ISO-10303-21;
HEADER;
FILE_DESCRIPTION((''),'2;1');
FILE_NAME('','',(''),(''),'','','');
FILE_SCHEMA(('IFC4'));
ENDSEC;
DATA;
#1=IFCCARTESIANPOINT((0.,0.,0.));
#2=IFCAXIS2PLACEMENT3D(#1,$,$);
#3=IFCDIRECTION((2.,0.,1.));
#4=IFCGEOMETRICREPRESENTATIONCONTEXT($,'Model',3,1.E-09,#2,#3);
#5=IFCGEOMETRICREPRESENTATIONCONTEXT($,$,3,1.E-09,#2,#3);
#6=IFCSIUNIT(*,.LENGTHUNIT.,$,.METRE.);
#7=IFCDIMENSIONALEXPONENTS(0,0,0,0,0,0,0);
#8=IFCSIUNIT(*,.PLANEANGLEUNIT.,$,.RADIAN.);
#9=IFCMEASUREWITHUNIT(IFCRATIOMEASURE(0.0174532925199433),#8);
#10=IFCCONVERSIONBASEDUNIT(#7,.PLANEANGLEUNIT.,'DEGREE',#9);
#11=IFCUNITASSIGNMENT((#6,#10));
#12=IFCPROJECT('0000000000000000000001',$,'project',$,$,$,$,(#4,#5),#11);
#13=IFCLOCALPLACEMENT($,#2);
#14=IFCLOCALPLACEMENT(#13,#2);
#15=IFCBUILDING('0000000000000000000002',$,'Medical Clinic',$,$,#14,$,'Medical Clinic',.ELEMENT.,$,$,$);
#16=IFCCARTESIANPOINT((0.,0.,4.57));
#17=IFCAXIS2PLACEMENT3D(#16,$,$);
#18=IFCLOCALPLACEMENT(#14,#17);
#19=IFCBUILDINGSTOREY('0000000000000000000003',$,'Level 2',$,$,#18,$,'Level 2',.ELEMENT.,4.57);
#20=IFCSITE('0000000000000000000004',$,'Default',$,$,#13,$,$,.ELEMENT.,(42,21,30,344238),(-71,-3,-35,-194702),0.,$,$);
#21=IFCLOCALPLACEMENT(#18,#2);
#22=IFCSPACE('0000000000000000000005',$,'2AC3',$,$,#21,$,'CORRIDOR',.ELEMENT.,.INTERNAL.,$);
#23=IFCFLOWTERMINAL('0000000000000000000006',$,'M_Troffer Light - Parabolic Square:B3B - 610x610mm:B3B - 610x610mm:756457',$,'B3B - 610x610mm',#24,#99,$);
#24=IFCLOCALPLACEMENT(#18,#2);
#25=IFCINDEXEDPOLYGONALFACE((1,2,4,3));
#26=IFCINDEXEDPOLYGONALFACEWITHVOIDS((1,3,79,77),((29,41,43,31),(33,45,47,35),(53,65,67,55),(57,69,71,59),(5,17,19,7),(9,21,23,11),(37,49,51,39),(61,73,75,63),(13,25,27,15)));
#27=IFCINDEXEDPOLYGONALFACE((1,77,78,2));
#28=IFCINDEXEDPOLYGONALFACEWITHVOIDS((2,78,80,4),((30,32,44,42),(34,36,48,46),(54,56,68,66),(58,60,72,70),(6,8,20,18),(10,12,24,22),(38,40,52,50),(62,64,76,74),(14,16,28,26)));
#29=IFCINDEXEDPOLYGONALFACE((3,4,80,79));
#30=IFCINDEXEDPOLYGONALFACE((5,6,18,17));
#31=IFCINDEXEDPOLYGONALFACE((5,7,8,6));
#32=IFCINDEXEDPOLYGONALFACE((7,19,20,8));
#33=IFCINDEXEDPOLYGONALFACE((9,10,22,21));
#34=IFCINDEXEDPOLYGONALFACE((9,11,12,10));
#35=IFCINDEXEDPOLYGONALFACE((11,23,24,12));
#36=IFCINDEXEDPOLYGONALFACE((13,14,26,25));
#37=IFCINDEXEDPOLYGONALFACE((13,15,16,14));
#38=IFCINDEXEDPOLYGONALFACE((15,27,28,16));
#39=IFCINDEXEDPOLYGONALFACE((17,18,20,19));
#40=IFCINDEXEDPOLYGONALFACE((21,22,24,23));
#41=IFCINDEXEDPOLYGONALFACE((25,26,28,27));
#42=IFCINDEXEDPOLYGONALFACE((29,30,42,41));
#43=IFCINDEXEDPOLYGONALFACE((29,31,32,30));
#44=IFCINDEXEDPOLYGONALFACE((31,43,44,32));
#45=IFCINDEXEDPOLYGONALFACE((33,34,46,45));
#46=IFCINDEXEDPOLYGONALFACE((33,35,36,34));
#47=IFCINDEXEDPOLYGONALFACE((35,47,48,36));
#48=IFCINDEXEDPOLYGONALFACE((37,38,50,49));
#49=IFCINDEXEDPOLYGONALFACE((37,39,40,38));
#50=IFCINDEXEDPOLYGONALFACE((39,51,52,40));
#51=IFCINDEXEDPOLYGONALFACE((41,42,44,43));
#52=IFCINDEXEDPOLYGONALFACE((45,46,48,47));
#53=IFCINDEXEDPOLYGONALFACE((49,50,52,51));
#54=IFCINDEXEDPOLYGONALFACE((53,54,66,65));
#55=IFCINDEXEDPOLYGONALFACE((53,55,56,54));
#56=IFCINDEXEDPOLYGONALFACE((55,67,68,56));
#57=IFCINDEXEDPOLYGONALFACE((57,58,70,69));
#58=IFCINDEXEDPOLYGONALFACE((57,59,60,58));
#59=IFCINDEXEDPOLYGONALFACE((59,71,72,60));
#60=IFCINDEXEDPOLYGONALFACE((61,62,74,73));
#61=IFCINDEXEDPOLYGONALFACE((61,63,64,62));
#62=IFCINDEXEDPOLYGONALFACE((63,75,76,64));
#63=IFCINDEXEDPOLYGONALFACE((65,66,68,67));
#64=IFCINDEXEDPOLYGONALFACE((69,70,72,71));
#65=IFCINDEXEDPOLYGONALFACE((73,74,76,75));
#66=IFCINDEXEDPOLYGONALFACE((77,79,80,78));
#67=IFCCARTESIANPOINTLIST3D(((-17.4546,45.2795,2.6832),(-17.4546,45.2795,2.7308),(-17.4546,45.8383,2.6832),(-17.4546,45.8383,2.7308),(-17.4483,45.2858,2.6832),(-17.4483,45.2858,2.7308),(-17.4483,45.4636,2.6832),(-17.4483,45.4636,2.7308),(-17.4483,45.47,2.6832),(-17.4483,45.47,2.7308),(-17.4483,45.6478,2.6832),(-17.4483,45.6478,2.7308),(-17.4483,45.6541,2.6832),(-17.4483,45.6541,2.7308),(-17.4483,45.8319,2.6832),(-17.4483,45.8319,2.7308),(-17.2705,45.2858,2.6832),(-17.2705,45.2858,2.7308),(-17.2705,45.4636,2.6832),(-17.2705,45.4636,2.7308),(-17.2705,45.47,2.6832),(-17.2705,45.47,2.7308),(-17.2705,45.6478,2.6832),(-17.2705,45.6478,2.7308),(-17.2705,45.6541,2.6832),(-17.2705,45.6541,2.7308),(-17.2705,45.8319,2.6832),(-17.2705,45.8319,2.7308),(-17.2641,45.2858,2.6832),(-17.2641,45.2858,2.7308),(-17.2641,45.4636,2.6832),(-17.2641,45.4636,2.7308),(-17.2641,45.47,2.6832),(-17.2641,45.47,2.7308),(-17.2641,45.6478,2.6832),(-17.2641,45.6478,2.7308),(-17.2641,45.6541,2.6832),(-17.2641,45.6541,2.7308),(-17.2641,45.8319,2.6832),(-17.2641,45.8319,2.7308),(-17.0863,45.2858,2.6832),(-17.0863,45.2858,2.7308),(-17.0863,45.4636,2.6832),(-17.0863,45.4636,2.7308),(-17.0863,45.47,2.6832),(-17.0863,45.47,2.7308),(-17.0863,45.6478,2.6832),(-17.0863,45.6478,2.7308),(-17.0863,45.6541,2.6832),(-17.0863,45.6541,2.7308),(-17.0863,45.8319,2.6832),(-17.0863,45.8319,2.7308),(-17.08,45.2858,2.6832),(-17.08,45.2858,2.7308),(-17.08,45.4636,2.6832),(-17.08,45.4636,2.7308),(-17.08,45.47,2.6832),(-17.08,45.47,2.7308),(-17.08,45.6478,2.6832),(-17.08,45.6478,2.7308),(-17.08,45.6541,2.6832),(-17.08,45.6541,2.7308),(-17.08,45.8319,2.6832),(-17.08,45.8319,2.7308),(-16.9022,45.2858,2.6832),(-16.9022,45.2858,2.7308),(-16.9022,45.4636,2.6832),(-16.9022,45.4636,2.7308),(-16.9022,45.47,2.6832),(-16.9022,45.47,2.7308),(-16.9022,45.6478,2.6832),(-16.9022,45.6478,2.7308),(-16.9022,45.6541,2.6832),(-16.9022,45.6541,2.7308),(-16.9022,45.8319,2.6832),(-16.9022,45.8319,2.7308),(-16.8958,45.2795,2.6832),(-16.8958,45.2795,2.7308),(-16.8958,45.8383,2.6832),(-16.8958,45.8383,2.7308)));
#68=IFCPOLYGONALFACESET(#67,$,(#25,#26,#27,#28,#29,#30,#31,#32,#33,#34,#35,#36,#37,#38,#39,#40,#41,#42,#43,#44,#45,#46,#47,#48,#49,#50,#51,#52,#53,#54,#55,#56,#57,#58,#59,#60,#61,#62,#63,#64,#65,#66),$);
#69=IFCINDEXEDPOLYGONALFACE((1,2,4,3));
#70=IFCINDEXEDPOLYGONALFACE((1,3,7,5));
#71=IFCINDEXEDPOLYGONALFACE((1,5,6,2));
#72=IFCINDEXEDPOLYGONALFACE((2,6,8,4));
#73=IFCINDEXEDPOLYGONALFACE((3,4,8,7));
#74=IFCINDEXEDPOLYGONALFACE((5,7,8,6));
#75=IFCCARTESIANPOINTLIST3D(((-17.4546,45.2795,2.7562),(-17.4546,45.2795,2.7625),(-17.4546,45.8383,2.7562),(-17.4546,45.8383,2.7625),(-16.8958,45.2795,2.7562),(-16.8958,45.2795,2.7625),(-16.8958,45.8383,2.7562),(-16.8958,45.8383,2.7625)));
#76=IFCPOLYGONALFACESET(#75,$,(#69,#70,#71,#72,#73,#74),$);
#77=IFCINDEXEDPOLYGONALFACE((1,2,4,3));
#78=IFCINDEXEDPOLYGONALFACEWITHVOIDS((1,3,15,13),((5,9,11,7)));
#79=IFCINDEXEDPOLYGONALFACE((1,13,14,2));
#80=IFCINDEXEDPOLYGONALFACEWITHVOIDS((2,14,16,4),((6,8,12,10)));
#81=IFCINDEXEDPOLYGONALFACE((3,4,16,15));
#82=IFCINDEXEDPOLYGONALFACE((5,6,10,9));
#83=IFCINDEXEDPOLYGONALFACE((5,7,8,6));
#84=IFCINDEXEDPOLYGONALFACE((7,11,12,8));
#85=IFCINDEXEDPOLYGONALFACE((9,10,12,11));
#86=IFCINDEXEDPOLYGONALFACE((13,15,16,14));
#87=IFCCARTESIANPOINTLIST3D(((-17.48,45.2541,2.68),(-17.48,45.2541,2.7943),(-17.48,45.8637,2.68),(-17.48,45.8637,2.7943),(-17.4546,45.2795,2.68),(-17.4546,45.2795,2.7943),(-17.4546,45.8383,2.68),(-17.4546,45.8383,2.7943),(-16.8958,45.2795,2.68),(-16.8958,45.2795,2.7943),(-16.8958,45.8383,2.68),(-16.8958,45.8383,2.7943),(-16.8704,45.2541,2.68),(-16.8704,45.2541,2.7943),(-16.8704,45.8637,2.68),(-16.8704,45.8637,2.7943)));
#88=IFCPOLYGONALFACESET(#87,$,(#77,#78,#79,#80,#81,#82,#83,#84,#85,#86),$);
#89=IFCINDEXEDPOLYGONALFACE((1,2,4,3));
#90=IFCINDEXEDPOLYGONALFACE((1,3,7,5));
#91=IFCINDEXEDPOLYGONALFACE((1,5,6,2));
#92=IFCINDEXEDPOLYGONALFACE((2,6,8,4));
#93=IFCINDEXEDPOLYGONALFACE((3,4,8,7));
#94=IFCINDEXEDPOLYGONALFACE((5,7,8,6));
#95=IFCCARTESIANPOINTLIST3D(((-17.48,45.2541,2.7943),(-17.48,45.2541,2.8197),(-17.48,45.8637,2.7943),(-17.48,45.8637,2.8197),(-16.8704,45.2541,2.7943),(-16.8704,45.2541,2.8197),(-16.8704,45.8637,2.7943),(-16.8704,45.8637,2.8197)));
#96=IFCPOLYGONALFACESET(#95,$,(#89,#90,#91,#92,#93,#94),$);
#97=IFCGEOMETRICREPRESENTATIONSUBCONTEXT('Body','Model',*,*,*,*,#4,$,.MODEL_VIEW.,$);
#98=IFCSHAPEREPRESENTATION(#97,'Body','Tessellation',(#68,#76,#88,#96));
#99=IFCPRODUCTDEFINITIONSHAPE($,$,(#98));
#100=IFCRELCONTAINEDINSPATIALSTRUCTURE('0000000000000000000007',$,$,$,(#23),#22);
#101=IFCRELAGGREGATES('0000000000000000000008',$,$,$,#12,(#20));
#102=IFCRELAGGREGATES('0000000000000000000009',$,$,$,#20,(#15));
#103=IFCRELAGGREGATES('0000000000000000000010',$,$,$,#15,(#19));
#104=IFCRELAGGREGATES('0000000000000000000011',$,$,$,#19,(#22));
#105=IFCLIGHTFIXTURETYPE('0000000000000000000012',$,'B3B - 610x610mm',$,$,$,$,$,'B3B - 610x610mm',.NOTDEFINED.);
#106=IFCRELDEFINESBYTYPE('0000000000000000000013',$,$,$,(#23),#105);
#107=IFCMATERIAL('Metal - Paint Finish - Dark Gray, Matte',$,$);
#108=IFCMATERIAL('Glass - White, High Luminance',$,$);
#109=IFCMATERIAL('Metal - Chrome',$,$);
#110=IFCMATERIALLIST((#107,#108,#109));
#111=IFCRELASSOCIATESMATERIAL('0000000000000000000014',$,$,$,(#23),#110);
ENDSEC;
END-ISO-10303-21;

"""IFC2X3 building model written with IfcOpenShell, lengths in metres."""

from ifc_helpers import new_model, entity, si_unit, converted_unit, direction, frame, origin, origin_2d_with_axis, place, context, subcontext, project, spatial, polyline, rectangle, outline, extrude, source, transform, mapped, material, material_list, type_object, type_shapes, element, save


model = new_model("IFC2X3")

# Units and contexts
model_context = context("Model", 3, precision=1e-09, world=origin(), true_north=direction((2.0, 0.0, 1.0)))
context_of_model = context(None, 3, precision=1e-09, world=origin(), true_north=direction((2.0, 0.0, 1.0)))
body_context = subcontext(model_context, "Body", "Model", "MODEL_VIEW")
ifc_project = project(units=[si_unit("LENGTHUNIT", "METRE"), converted_unit("PLANEANGLEUNIT", "DEGREE", entity("IfcRatioMeasure", 0.0174532925199433), si_unit("PLANEANGLEUNIT", "RADIAN"), dimensions=[0, 0, 0, 0, 0, 0, 0])], contexts=[model_context, context_of_model])

# Site, building, storey
site_placement = place(None, origin())
site = spatial("IfcSite", under=ifc_project, at=site_placement, Name="Default", CompositionType="ELEMENT", RefLatitude=(42, 21, 30, 344238), RefLongitude=(-71, -3, -35, -194702), RefElevation=0.0)
building_placement = place(site_placement, origin())
building = spatial("IfcBuilding", under=site, at=building_placement, Name="Medical Clinic", LongName="Medical Clinic", CompositionType="ELEMENT")
storey_placement = place(building_placement, frame((0.0, 0.0, 4.57)))
storey = spatial("IfcBuildingStorey", under=building, at=storey_placement, Name="Level 2", LongName="Level 2", CompositionType="ELEMENT", Elevation=4.57)

# Shared definitions
ifc_material_1 = material(Name="Metal - Paint Finish - Dark Gray, Matte")
ifc_material_2 = material(Name="Glass - White, High Luminance")
ifc_material_3 = material(Name="Metal - Chrome")
ifc_material_list = material_list([ifc_material_1, ifc_material_2, ifc_material_3])

# Shared definitions
space_1_placement = place(storey_placement, origin())
space_1 = spatial("IfcSpace", under=storey, at=space_1_placement, Name="2AC3", LongName="CORRIDOR", CompositionType="ELEMENT", InteriorOrExteriorSpace="INTERNAL")

# Flow terminal
light_fixture_type_1 = type_object("IfcLightFixtureType", Name="B3B - 610x610mm", ElementType="B3B - 610x610mm", PredefinedType="NOTDEFINED")
shared_shape_1 = source(origin(), body_context, "Body", "SweptSolid", [
    extrude(outline(polyline([(-0.2794, -0.2794), (0.2794, -0.2794), (0.2794, 0.2794), (-0.2794, 0.2794), (-0.2794, -0.2794)]), holes=[polyline([(-0.0952, 0.0953), (-0.273, 0.0953), (-0.273, 0.2731), (-0.0952, 0.2731), (-0.0952, 0.0953)]), polyline([(0.2731, 0.0953), (0.0953, 0.0953), (0.0953, 0.2731), (0.2731, 0.2731), (0.2731, 0.0953)]), polyline([(-0.0889, 0.2731), (0.0889, 0.2731), (0.0889, 0.0953), (-0.0889, 0.0953), (-0.0889, 0.2731)]), polyline([(0.2731, -0.273), (0.0953, -0.273), (0.0953, -0.0952), (0.2731, -0.0952), (0.2731, -0.273)]), polyline([(0.0889, -0.273), (-0.0889, -0.273), (-0.0889, -0.0952), (0.0889, -0.0952), (0.0889, -0.273)]), polyline([(-0.0952, -0.273), (-0.273, -0.273), (-0.273, -0.0952), (-0.0952, -0.0952), (-0.0952, -0.273)]), polyline([(-0.0952, -0.0889), (-0.273, -0.0889), (-0.273, 0.0889), (-0.0952, 0.0889), (-0.0952, -0.0889)]), polyline([(0.0889, -0.0889), (-0.0889, -0.0889), (-0.0889, 0.0889), (0.0889, 0.0889), (0.0889, -0.0889)]), polyline([(0.2731, -0.0889), (0.0953, -0.0889), (0.0953, 0.0889), (0.2731, 0.0889), (0.2731, -0.0889)])]), frame((0.0, -0.3048, -0.0508), z_axis=(0.0, 0.0, 1.0), x_axis=(-1.0, 0.0, 0.0)), (0.0, 0.0, 1.0), 0.0476),
    extrude(rectangle(XDim=0.5588, YDim=0.5588, at=origin_2d_with_axis()), frame((0.0, -0.3048, -0.0825), z_axis=(0.0, 0.0, 1.0), x_axis=(-1.0, 0.0, 0.0)), (0.0, 0.0, 1.0), 0.0064),
    extrude(outline(polyline([(-0.3048, -0.3048), (0.3048, -0.3048), (0.3048, 0.3048), (-0.3048, 0.3048), (-0.3048, -0.3048)]), holes=[polyline([(0.2794, 0.2794), (0.2794, -0.2794), (-0.2794, -0.2794), (-0.2794, 0.2794), (0.2794, 0.2794)])]), frame((0.0, -0.3048, -0.1143)), (0.0, 0.0, 1.0), 0.1143),
    extrude(rectangle(XDim=0.6096, YDim=0.6096, at=origin_2d_with_axis()), frame((0.0, -0.3048, -0.1397), z_axis=(0.0, 0.0, 1.0), x_axis=(-1.0, 0.0, 0.0)), (0.0, 0.0, 1.0), 0.0254),
])
type_shapes(light_fixture_type_1, [shared_shape_1])
flow_terminal_1_placement = place(space_1_placement, frame((-17.1752, 45.2541, 2.68), z_axis=(0.0, 0.0, -1.0), x_axis=(1.0, 0.0, 0.0)))
element("IfcFlowTerminal", 1, at=flow_terminal_1_placement, inside=space_1, type_object=light_fixture_type_1, material=ifc_material_list, Name="M_Troffer Light - Parabolic Square:B3B - 610x610mm:B3B - 610x610mm:756457", ObjectType="B3B - 610x610mm", context=body_context, shape_type="MappedRepresentation", body=[
    mapped(shared_shape_1, transform((0.0, 0.0, 0.0), scale=1.0)),
])

save(model, "model.ifc")
